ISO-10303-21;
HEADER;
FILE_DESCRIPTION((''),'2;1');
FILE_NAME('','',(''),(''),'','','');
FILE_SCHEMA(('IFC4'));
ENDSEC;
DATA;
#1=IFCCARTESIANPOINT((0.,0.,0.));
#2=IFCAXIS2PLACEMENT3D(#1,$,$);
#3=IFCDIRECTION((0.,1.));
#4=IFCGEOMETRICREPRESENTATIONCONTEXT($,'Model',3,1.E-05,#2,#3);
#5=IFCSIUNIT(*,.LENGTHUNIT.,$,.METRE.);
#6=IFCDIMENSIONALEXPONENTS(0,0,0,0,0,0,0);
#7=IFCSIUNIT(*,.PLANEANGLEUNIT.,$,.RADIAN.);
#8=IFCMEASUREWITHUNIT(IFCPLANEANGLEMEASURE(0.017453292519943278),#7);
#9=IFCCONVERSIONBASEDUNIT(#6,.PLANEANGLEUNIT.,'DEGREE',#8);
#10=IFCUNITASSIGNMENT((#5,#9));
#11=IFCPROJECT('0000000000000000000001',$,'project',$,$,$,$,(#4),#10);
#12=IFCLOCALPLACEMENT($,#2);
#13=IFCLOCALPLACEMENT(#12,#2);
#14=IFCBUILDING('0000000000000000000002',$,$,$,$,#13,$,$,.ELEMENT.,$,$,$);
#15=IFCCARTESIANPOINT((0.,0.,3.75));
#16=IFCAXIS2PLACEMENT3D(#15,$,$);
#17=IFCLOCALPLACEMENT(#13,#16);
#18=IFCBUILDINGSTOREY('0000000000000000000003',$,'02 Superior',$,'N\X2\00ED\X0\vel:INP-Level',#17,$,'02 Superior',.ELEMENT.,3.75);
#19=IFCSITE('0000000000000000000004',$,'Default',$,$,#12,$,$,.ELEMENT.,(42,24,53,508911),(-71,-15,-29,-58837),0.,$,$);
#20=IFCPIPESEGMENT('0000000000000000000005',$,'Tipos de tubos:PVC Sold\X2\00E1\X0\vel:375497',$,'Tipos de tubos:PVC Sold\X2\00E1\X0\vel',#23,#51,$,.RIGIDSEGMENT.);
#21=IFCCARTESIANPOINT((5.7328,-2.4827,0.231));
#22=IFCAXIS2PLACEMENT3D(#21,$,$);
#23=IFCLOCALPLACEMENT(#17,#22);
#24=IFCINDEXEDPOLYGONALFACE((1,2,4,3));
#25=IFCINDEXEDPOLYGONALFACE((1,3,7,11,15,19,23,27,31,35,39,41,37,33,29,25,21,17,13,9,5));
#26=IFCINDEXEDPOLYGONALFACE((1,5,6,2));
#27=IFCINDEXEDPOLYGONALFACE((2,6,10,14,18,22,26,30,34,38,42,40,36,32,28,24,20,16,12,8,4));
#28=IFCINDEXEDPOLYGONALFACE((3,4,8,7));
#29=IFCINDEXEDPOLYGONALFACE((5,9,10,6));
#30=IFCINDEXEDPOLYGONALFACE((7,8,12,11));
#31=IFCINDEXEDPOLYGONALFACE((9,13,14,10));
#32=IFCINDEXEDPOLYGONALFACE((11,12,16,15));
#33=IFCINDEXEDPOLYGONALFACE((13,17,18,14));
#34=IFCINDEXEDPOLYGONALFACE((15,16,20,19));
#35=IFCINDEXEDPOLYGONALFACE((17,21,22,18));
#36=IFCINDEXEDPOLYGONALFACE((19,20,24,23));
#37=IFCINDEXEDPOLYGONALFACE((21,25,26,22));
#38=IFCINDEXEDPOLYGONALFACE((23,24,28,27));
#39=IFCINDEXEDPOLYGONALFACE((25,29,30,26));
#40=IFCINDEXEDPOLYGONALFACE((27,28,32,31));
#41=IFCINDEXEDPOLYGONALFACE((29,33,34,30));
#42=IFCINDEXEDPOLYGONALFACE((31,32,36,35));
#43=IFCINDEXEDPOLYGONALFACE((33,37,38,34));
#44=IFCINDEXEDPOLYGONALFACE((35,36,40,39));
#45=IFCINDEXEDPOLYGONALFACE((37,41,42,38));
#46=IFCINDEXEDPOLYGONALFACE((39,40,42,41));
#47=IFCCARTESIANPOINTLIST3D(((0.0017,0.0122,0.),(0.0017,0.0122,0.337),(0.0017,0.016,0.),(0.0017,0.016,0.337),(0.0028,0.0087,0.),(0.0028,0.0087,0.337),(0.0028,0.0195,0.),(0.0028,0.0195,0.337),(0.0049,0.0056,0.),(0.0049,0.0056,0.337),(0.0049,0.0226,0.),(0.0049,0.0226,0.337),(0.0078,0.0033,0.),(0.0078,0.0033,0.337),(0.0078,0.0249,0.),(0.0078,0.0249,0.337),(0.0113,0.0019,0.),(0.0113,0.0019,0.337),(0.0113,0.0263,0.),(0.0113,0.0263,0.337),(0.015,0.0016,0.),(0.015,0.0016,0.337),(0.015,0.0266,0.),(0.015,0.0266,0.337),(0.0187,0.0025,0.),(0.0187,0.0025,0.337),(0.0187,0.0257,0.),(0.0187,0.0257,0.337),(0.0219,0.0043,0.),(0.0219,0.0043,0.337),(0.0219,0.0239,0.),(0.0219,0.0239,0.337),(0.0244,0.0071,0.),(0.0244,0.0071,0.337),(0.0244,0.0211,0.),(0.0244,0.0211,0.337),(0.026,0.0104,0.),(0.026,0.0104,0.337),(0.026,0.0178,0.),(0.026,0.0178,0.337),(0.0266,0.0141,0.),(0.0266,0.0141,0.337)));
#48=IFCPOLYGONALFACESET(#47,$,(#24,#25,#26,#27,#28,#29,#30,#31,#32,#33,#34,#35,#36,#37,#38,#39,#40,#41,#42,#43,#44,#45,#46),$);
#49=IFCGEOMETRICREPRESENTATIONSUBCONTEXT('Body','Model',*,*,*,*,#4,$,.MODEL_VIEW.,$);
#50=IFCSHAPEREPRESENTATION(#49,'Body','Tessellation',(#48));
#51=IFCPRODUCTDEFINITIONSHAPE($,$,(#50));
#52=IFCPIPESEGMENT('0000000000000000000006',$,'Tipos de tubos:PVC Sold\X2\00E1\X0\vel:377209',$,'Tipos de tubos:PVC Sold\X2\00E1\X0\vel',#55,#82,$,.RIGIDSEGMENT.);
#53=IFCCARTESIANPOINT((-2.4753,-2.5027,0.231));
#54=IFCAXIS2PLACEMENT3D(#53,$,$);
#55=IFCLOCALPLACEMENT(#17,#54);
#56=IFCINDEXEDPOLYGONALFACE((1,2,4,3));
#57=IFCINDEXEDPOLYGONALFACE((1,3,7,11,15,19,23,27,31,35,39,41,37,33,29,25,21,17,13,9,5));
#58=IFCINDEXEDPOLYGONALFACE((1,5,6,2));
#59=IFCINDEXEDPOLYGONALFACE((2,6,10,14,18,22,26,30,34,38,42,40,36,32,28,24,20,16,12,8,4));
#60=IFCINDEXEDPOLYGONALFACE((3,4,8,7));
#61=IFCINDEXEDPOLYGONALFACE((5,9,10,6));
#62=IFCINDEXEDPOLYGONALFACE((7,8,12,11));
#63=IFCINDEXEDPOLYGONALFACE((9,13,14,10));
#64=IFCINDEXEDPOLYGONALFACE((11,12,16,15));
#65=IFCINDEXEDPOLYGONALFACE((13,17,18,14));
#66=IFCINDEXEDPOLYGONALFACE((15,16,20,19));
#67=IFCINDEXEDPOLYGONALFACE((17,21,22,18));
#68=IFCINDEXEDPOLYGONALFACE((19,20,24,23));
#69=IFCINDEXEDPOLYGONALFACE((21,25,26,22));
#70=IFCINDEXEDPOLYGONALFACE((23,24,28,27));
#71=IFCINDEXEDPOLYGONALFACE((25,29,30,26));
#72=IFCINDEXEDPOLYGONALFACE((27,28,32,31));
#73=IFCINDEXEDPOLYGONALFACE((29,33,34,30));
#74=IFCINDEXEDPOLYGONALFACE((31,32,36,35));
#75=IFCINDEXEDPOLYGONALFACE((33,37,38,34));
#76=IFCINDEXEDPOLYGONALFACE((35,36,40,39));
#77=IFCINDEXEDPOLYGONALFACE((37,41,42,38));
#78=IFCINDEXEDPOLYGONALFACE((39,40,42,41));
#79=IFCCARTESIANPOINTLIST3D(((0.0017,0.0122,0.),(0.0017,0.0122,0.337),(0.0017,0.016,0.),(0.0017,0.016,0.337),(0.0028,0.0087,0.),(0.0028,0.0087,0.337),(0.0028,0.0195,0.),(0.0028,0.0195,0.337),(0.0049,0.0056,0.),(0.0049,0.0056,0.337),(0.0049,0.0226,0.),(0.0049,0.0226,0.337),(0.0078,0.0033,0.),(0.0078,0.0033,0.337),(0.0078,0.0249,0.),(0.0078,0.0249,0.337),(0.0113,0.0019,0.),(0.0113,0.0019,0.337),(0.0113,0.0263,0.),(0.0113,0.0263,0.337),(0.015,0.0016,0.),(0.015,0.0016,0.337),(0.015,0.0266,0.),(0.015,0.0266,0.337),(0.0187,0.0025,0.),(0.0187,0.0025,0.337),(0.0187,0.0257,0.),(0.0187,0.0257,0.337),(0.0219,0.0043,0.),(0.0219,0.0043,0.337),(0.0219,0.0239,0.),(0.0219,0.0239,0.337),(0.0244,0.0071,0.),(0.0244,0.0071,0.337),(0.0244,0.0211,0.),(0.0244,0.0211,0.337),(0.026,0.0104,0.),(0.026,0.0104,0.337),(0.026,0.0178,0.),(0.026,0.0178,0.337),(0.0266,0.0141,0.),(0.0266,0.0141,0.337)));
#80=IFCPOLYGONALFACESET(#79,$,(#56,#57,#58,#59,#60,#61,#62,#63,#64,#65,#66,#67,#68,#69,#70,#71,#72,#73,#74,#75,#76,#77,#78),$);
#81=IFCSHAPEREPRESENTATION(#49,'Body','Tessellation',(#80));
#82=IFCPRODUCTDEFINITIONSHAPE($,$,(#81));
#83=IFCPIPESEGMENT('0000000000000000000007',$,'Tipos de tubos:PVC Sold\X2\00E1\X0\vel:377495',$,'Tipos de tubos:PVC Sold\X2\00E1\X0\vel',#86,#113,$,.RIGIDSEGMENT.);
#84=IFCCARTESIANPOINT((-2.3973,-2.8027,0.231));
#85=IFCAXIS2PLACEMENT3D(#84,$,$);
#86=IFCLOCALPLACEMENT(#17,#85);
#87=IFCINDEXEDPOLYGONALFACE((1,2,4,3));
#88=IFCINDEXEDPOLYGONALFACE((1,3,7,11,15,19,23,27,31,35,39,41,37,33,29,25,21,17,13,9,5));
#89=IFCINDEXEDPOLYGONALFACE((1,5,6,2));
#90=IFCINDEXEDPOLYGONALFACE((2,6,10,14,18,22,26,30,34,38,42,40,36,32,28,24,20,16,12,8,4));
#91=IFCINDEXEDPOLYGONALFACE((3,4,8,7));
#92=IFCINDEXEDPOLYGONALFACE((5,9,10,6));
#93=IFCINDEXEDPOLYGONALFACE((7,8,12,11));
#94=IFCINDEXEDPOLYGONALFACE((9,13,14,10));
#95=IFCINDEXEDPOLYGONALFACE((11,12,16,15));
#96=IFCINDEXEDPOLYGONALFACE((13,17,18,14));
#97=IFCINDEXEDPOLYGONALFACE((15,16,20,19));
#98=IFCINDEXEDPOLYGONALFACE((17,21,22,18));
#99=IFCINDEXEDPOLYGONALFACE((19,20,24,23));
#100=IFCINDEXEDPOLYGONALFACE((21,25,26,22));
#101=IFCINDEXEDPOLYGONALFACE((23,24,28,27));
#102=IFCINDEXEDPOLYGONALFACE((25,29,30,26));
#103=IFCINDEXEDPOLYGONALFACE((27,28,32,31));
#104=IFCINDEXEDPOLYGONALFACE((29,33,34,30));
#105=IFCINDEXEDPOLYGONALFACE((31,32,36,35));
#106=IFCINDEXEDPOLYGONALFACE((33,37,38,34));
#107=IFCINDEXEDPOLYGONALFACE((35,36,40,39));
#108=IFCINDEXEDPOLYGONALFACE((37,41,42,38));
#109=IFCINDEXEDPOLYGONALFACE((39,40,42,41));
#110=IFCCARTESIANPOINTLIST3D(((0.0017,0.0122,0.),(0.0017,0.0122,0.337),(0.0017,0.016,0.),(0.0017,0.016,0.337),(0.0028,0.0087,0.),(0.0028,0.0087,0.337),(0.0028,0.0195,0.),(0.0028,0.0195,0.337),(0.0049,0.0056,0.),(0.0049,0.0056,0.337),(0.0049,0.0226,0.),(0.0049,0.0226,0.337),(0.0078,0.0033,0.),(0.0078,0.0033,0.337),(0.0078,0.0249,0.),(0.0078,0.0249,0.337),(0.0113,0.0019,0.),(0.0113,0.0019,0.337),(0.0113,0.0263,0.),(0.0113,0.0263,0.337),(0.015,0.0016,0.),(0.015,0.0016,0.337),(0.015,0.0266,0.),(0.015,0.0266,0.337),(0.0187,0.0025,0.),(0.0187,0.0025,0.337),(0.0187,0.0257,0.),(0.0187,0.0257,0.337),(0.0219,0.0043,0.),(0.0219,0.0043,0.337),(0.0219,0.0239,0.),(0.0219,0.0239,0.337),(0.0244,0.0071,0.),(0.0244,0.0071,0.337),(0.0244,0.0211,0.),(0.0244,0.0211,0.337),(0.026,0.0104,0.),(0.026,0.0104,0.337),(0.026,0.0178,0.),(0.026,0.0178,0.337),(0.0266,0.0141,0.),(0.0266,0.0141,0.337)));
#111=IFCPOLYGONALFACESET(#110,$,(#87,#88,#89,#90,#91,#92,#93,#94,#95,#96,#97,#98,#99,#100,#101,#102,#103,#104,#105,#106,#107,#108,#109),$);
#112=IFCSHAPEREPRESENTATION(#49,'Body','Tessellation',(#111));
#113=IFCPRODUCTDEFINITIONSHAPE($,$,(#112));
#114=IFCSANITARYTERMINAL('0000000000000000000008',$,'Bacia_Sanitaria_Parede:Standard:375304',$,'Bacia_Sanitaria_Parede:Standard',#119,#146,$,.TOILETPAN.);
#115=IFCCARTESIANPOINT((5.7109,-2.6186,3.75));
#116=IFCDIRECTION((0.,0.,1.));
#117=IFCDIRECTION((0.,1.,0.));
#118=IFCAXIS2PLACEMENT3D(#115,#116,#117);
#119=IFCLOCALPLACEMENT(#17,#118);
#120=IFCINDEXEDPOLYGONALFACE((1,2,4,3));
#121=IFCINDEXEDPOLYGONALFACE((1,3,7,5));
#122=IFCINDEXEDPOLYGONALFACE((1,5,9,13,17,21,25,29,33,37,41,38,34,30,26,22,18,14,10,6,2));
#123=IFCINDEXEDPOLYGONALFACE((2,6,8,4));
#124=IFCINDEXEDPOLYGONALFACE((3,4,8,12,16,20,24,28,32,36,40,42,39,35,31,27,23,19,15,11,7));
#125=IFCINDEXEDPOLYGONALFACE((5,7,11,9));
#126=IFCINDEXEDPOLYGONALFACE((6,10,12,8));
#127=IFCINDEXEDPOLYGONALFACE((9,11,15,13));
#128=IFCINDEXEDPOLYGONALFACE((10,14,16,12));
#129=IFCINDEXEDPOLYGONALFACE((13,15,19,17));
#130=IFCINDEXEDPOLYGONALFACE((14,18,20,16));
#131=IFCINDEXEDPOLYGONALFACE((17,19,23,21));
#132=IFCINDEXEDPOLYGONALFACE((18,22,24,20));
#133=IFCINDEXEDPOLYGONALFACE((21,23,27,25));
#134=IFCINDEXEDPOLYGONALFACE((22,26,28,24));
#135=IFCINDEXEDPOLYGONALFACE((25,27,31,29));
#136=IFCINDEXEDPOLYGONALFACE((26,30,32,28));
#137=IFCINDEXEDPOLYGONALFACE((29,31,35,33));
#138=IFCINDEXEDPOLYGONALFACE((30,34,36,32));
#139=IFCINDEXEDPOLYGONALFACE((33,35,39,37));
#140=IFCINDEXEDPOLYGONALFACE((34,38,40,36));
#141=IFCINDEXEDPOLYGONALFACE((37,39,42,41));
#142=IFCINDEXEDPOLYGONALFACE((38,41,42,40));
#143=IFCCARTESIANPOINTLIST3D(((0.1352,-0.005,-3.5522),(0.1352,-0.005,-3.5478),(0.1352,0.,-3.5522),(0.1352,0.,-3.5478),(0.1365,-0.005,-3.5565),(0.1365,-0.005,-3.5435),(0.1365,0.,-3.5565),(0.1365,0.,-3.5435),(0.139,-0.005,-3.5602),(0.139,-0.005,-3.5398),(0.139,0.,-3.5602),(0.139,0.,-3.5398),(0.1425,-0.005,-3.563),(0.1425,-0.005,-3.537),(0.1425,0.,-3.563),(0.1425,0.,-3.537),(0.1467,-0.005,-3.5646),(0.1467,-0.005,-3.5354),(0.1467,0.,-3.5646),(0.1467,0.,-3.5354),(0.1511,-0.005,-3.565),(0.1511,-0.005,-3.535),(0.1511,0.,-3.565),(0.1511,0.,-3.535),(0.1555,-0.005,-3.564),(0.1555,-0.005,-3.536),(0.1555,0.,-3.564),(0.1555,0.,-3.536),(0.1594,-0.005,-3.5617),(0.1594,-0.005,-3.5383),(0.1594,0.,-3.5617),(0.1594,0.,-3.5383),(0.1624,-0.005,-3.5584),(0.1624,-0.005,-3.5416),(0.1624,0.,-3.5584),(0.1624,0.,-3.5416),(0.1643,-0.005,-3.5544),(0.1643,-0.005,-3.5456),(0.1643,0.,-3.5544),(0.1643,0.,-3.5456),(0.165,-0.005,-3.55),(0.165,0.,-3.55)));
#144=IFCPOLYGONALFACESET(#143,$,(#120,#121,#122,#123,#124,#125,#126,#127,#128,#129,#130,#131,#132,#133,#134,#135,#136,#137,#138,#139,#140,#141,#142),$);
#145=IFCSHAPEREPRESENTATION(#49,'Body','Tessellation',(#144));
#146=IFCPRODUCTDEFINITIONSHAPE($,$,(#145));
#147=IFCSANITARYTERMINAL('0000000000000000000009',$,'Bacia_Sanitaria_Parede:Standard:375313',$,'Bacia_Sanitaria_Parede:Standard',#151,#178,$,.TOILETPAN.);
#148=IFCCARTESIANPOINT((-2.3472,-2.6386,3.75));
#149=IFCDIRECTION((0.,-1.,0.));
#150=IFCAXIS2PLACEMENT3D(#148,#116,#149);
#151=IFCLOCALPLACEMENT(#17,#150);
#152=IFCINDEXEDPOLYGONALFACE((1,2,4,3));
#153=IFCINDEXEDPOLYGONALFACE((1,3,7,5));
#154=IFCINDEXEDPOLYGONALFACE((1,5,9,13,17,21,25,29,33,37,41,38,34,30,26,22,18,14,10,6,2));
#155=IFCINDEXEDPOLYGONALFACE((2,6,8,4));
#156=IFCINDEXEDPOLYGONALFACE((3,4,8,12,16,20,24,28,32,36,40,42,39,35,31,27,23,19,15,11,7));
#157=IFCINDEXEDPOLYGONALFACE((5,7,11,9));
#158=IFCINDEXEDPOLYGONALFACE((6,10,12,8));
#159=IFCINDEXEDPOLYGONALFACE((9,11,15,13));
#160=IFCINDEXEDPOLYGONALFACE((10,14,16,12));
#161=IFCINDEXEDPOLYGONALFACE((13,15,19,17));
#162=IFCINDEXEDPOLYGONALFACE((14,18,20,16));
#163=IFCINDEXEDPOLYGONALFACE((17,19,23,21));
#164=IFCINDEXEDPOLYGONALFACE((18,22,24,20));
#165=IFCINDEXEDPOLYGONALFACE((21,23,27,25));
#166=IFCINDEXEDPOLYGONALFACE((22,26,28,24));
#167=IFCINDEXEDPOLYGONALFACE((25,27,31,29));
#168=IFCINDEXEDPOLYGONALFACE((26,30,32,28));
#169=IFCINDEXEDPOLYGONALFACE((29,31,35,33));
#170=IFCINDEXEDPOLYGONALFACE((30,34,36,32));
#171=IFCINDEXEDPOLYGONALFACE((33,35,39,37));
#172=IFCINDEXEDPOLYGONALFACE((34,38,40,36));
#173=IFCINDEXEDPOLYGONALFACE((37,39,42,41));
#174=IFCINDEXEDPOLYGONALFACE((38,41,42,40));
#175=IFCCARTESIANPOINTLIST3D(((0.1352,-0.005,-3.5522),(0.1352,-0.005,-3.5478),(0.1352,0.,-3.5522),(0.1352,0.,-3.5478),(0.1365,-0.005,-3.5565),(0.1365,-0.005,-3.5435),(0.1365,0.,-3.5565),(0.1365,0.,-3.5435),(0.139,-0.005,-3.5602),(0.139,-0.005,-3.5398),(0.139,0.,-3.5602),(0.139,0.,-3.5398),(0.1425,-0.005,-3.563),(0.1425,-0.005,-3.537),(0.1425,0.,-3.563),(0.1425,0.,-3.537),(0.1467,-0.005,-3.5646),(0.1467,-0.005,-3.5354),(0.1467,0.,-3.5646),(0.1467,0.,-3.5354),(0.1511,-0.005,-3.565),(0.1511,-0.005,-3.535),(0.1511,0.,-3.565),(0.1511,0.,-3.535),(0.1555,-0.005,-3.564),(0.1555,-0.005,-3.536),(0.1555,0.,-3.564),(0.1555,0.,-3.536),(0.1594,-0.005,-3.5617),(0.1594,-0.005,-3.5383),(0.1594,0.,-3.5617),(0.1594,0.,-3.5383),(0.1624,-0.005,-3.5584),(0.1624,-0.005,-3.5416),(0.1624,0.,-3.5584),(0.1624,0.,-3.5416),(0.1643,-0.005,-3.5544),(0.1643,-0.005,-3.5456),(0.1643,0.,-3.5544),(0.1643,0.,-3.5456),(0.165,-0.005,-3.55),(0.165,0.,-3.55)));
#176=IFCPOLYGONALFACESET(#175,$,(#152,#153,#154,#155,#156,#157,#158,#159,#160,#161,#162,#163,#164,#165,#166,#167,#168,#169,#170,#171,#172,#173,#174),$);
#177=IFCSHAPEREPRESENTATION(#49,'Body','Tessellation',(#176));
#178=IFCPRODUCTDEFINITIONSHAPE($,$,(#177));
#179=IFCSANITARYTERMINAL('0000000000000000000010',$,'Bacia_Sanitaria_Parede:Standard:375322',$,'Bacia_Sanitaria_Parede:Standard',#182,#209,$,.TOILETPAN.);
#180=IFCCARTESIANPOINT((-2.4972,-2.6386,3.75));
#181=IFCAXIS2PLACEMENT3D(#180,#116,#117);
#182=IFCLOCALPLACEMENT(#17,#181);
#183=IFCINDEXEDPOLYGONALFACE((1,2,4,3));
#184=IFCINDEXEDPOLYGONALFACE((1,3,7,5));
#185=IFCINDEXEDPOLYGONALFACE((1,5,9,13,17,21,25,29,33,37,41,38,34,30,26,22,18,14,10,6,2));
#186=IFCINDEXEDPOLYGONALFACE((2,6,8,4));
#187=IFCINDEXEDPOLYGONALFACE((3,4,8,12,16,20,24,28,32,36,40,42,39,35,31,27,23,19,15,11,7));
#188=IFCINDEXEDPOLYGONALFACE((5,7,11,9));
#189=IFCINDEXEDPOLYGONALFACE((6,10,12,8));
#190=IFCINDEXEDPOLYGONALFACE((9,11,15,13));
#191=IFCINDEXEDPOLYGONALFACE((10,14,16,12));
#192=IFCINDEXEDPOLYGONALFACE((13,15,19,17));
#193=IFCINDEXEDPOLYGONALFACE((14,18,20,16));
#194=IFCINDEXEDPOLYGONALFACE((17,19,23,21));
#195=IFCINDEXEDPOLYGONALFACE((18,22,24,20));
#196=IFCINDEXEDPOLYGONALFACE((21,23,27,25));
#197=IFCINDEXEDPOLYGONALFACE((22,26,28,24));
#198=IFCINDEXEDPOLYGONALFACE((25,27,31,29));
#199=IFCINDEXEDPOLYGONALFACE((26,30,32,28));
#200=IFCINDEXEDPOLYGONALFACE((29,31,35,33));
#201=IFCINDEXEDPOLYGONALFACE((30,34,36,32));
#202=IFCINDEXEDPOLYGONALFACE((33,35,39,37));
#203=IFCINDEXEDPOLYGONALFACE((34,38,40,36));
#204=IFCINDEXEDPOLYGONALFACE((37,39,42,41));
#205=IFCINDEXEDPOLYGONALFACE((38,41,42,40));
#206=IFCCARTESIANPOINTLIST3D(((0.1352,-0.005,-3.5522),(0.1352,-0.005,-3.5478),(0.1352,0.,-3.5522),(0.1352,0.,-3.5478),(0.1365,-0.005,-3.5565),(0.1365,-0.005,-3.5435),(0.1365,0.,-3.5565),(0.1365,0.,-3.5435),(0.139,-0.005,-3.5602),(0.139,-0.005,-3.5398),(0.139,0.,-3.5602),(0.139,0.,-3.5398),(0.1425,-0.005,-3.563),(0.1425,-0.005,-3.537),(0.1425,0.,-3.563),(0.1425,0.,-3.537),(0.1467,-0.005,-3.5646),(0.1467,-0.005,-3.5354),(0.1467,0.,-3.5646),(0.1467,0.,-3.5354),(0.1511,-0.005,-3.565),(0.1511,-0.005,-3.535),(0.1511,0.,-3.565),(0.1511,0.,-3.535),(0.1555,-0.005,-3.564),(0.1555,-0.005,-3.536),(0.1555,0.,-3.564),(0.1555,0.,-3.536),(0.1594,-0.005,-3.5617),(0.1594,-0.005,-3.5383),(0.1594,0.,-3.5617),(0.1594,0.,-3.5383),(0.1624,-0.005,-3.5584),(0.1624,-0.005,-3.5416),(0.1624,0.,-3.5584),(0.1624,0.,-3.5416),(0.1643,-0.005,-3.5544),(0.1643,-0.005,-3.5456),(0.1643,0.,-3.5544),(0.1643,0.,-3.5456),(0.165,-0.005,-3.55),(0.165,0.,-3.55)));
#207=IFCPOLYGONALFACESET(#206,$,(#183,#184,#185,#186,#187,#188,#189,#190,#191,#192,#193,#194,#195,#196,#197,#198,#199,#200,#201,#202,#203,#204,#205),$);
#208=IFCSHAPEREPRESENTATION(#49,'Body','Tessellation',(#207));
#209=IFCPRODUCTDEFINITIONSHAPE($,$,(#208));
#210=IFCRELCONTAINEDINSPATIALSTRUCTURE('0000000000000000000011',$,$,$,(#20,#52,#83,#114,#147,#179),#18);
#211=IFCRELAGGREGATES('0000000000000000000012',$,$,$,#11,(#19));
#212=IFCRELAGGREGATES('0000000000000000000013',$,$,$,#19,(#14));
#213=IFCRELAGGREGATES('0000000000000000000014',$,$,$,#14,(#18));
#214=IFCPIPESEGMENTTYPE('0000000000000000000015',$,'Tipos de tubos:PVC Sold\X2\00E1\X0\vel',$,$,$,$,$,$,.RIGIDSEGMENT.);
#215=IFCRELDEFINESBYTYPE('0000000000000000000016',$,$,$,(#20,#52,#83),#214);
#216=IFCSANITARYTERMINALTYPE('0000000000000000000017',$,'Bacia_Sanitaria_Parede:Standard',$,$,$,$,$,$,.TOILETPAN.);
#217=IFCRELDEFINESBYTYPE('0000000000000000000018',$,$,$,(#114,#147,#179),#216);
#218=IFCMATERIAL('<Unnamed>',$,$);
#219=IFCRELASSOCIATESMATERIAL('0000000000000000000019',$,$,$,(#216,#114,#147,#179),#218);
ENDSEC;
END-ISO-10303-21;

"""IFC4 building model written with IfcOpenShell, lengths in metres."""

from ifc_helpers import new_model, entity, si_unit, converted_unit, direction, frame, frame_2d, origin, origin_2d_with_axis, place, context, subcontext, project, spatial, circle, extrude, source, transform, mapped, material, type_object, type_shapes, element, save


model = new_model("IFC4")

# Units and contexts
model_context = context("Model", 3, precision=1e-05, world=origin(), true_north=direction((0.0, 1.0)))
body_context = subcontext(model_context, "Body", "Model", "MODEL_VIEW")
ifc_project = project(units=[si_unit("LENGTHUNIT", "METRE"), converted_unit("PLANEANGLEUNIT", "DEGREE", entity("IfcPlaneAngleMeasure", 0.017453292519943278), si_unit("PLANEANGLEUNIT", "RADIAN"), dimensions=[0, 0, 0, 0, 0, 0, 0])], contexts=[model_context])

# Site, building, storey
site_placement = place(None, origin())
site = spatial("IfcSite", under=ifc_project, at=site_placement, Name="Default", CompositionType="ELEMENT", RefLatitude=(42, 24, 53, 508911), RefLongitude=(-71, -15, -29, -58837), RefElevation=0.0)
building_placement = place(site_placement, origin())
building = spatial("IfcBuilding", under=site, at=building_placement, CompositionType="ELEMENT")
storey_placement = place(building_placement, frame((0.0, 0.0, 3.75)))
storey = spatial("IfcBuildingStorey", under=building, at=storey_placement, Name="02 Superior", ObjectType="Nível:INP-Level", LongName="02 Superior", CompositionType="ELEMENT", Elevation=3.75)

# Pipe segments
pipe_segment_type = type_object("IfcPipeSegmentType", Name="Tipos de tubos:PVC Soldável", PredefinedType="RIGIDSEGMENT")
pipe_segment_1_placement = place(storey_placement, frame((5.7328, -2.4827, 0.231)))
element("IfcPipeSegment", 1, at=pipe_segment_1_placement, inside=storey, type_object=pipe_segment_type, Name="Tipos de tubos:PVC Soldável:375497", ObjectType="Tipos de tubos:PVC Soldável", PredefinedType="RIGIDSEGMENT", context=body_context, shape_type="SweptSolid", body=[
    extrude(circle(Radius=0.0125, at=origin_2d_with_axis()), frame((0.0141, 0.0141, 0.0)), (0.0, 0.0, 1.0), 0.337),
])
pipe_segment_2_placement = place(storey_placement, frame((-2.4753, -2.5027, 0.231)))
element("IfcPipeSegment", 2, at=pipe_segment_2_placement, inside=storey, type_object=pipe_segment_type, Name="Tipos de tubos:PVC Soldável:377209", ObjectType="Tipos de tubos:PVC Soldável", PredefinedType="RIGIDSEGMENT", context=body_context, shape_type="SweptSolid", body=[
    extrude(circle(Radius=0.0125, at=frame_2d((0.0, 0.0), x_axis=(1.0, 0.0))), frame((0.0141, 0.0141, 0.0)), (0.0, 0.0, 1.0), 0.337),
])
pipe_segment_3_placement = place(storey_placement, frame((-2.3973, -2.8027, 0.231)))
element("IfcPipeSegment", 3, at=pipe_segment_3_placement, inside=storey, type_object=pipe_segment_type, Name="Tipos de tubos:PVC Soldável:377495", ObjectType="Tipos de tubos:PVC Soldável", PredefinedType="RIGIDSEGMENT", context=body_context, shape_type="SweptSolid", body=[
    extrude(circle(Radius=0.0125, at=frame_2d((0.0, 0.0), x_axis=(1.0, 0.0))), frame((0.0141, 0.0141, 0.0)), (0.0, 0.0, 1.0), 0.337),
])

# Sanitary terminals
ifc_material = material(Name="<Unnamed>")
sanitary_terminal_type = type_object("IfcSanitaryTerminalType", Name="Bacia_Sanitaria_Parede:Standard", PredefinedType="TOILETPAN", material=ifc_material)
shared_shape = source(origin(), body_context, "Body", "SweptSolid", [
    extrude(circle(Radius=0.015, at=frame_2d((0.0, 0.0), x_axis=(1.0, 0.0))), frame((0.15, -0.005, -3.55), z_axis=(0.0, 1.0, 0.0), x_axis=(1.0, 0.0, 0.0)), (0.0, 0.0, 1.0), 0.005),
])
type_shapes(sanitary_terminal_type, [shared_shape])
for number, where, z_axis, x_axis, name in (
    (4, (5.7109, -2.6186, 3.75), (0.0, 0.0, 1.0), (0.0, 1.0, 0.0), "Bacia_Sanitaria_Parede:Standard:375304"),
    (5, (-2.3472, -2.6386, 3.75), (0.0, 0.0, 1.0), (0.0, -1.0, 0.0), "Bacia_Sanitaria_Parede:Standard:375313"),
    (6, (-2.4972, -2.6386, 3.75), (0.0, 0.0, 1.0), (0.0, 1.0, 0.0), "Bacia_Sanitaria_Parede:Standard:375322"),
):
    element("IfcSanitaryTerminal", number, at=place(storey_placement, frame(where, z_axis=z_axis, x_axis=x_axis)), inside=storey, type_object=sanitary_terminal_type, material=ifc_material, Name=name, ObjectType="Bacia_Sanitaria_Parede:Standard", PredefinedType="TOILETPAN", context=body_context, shape_type="MappedRepresentation", body=[
        mapped(shared_shape, transform((0.0, 0.0, 0.0), scale=1.0)),
    ])

save(model, "model.ifc")
